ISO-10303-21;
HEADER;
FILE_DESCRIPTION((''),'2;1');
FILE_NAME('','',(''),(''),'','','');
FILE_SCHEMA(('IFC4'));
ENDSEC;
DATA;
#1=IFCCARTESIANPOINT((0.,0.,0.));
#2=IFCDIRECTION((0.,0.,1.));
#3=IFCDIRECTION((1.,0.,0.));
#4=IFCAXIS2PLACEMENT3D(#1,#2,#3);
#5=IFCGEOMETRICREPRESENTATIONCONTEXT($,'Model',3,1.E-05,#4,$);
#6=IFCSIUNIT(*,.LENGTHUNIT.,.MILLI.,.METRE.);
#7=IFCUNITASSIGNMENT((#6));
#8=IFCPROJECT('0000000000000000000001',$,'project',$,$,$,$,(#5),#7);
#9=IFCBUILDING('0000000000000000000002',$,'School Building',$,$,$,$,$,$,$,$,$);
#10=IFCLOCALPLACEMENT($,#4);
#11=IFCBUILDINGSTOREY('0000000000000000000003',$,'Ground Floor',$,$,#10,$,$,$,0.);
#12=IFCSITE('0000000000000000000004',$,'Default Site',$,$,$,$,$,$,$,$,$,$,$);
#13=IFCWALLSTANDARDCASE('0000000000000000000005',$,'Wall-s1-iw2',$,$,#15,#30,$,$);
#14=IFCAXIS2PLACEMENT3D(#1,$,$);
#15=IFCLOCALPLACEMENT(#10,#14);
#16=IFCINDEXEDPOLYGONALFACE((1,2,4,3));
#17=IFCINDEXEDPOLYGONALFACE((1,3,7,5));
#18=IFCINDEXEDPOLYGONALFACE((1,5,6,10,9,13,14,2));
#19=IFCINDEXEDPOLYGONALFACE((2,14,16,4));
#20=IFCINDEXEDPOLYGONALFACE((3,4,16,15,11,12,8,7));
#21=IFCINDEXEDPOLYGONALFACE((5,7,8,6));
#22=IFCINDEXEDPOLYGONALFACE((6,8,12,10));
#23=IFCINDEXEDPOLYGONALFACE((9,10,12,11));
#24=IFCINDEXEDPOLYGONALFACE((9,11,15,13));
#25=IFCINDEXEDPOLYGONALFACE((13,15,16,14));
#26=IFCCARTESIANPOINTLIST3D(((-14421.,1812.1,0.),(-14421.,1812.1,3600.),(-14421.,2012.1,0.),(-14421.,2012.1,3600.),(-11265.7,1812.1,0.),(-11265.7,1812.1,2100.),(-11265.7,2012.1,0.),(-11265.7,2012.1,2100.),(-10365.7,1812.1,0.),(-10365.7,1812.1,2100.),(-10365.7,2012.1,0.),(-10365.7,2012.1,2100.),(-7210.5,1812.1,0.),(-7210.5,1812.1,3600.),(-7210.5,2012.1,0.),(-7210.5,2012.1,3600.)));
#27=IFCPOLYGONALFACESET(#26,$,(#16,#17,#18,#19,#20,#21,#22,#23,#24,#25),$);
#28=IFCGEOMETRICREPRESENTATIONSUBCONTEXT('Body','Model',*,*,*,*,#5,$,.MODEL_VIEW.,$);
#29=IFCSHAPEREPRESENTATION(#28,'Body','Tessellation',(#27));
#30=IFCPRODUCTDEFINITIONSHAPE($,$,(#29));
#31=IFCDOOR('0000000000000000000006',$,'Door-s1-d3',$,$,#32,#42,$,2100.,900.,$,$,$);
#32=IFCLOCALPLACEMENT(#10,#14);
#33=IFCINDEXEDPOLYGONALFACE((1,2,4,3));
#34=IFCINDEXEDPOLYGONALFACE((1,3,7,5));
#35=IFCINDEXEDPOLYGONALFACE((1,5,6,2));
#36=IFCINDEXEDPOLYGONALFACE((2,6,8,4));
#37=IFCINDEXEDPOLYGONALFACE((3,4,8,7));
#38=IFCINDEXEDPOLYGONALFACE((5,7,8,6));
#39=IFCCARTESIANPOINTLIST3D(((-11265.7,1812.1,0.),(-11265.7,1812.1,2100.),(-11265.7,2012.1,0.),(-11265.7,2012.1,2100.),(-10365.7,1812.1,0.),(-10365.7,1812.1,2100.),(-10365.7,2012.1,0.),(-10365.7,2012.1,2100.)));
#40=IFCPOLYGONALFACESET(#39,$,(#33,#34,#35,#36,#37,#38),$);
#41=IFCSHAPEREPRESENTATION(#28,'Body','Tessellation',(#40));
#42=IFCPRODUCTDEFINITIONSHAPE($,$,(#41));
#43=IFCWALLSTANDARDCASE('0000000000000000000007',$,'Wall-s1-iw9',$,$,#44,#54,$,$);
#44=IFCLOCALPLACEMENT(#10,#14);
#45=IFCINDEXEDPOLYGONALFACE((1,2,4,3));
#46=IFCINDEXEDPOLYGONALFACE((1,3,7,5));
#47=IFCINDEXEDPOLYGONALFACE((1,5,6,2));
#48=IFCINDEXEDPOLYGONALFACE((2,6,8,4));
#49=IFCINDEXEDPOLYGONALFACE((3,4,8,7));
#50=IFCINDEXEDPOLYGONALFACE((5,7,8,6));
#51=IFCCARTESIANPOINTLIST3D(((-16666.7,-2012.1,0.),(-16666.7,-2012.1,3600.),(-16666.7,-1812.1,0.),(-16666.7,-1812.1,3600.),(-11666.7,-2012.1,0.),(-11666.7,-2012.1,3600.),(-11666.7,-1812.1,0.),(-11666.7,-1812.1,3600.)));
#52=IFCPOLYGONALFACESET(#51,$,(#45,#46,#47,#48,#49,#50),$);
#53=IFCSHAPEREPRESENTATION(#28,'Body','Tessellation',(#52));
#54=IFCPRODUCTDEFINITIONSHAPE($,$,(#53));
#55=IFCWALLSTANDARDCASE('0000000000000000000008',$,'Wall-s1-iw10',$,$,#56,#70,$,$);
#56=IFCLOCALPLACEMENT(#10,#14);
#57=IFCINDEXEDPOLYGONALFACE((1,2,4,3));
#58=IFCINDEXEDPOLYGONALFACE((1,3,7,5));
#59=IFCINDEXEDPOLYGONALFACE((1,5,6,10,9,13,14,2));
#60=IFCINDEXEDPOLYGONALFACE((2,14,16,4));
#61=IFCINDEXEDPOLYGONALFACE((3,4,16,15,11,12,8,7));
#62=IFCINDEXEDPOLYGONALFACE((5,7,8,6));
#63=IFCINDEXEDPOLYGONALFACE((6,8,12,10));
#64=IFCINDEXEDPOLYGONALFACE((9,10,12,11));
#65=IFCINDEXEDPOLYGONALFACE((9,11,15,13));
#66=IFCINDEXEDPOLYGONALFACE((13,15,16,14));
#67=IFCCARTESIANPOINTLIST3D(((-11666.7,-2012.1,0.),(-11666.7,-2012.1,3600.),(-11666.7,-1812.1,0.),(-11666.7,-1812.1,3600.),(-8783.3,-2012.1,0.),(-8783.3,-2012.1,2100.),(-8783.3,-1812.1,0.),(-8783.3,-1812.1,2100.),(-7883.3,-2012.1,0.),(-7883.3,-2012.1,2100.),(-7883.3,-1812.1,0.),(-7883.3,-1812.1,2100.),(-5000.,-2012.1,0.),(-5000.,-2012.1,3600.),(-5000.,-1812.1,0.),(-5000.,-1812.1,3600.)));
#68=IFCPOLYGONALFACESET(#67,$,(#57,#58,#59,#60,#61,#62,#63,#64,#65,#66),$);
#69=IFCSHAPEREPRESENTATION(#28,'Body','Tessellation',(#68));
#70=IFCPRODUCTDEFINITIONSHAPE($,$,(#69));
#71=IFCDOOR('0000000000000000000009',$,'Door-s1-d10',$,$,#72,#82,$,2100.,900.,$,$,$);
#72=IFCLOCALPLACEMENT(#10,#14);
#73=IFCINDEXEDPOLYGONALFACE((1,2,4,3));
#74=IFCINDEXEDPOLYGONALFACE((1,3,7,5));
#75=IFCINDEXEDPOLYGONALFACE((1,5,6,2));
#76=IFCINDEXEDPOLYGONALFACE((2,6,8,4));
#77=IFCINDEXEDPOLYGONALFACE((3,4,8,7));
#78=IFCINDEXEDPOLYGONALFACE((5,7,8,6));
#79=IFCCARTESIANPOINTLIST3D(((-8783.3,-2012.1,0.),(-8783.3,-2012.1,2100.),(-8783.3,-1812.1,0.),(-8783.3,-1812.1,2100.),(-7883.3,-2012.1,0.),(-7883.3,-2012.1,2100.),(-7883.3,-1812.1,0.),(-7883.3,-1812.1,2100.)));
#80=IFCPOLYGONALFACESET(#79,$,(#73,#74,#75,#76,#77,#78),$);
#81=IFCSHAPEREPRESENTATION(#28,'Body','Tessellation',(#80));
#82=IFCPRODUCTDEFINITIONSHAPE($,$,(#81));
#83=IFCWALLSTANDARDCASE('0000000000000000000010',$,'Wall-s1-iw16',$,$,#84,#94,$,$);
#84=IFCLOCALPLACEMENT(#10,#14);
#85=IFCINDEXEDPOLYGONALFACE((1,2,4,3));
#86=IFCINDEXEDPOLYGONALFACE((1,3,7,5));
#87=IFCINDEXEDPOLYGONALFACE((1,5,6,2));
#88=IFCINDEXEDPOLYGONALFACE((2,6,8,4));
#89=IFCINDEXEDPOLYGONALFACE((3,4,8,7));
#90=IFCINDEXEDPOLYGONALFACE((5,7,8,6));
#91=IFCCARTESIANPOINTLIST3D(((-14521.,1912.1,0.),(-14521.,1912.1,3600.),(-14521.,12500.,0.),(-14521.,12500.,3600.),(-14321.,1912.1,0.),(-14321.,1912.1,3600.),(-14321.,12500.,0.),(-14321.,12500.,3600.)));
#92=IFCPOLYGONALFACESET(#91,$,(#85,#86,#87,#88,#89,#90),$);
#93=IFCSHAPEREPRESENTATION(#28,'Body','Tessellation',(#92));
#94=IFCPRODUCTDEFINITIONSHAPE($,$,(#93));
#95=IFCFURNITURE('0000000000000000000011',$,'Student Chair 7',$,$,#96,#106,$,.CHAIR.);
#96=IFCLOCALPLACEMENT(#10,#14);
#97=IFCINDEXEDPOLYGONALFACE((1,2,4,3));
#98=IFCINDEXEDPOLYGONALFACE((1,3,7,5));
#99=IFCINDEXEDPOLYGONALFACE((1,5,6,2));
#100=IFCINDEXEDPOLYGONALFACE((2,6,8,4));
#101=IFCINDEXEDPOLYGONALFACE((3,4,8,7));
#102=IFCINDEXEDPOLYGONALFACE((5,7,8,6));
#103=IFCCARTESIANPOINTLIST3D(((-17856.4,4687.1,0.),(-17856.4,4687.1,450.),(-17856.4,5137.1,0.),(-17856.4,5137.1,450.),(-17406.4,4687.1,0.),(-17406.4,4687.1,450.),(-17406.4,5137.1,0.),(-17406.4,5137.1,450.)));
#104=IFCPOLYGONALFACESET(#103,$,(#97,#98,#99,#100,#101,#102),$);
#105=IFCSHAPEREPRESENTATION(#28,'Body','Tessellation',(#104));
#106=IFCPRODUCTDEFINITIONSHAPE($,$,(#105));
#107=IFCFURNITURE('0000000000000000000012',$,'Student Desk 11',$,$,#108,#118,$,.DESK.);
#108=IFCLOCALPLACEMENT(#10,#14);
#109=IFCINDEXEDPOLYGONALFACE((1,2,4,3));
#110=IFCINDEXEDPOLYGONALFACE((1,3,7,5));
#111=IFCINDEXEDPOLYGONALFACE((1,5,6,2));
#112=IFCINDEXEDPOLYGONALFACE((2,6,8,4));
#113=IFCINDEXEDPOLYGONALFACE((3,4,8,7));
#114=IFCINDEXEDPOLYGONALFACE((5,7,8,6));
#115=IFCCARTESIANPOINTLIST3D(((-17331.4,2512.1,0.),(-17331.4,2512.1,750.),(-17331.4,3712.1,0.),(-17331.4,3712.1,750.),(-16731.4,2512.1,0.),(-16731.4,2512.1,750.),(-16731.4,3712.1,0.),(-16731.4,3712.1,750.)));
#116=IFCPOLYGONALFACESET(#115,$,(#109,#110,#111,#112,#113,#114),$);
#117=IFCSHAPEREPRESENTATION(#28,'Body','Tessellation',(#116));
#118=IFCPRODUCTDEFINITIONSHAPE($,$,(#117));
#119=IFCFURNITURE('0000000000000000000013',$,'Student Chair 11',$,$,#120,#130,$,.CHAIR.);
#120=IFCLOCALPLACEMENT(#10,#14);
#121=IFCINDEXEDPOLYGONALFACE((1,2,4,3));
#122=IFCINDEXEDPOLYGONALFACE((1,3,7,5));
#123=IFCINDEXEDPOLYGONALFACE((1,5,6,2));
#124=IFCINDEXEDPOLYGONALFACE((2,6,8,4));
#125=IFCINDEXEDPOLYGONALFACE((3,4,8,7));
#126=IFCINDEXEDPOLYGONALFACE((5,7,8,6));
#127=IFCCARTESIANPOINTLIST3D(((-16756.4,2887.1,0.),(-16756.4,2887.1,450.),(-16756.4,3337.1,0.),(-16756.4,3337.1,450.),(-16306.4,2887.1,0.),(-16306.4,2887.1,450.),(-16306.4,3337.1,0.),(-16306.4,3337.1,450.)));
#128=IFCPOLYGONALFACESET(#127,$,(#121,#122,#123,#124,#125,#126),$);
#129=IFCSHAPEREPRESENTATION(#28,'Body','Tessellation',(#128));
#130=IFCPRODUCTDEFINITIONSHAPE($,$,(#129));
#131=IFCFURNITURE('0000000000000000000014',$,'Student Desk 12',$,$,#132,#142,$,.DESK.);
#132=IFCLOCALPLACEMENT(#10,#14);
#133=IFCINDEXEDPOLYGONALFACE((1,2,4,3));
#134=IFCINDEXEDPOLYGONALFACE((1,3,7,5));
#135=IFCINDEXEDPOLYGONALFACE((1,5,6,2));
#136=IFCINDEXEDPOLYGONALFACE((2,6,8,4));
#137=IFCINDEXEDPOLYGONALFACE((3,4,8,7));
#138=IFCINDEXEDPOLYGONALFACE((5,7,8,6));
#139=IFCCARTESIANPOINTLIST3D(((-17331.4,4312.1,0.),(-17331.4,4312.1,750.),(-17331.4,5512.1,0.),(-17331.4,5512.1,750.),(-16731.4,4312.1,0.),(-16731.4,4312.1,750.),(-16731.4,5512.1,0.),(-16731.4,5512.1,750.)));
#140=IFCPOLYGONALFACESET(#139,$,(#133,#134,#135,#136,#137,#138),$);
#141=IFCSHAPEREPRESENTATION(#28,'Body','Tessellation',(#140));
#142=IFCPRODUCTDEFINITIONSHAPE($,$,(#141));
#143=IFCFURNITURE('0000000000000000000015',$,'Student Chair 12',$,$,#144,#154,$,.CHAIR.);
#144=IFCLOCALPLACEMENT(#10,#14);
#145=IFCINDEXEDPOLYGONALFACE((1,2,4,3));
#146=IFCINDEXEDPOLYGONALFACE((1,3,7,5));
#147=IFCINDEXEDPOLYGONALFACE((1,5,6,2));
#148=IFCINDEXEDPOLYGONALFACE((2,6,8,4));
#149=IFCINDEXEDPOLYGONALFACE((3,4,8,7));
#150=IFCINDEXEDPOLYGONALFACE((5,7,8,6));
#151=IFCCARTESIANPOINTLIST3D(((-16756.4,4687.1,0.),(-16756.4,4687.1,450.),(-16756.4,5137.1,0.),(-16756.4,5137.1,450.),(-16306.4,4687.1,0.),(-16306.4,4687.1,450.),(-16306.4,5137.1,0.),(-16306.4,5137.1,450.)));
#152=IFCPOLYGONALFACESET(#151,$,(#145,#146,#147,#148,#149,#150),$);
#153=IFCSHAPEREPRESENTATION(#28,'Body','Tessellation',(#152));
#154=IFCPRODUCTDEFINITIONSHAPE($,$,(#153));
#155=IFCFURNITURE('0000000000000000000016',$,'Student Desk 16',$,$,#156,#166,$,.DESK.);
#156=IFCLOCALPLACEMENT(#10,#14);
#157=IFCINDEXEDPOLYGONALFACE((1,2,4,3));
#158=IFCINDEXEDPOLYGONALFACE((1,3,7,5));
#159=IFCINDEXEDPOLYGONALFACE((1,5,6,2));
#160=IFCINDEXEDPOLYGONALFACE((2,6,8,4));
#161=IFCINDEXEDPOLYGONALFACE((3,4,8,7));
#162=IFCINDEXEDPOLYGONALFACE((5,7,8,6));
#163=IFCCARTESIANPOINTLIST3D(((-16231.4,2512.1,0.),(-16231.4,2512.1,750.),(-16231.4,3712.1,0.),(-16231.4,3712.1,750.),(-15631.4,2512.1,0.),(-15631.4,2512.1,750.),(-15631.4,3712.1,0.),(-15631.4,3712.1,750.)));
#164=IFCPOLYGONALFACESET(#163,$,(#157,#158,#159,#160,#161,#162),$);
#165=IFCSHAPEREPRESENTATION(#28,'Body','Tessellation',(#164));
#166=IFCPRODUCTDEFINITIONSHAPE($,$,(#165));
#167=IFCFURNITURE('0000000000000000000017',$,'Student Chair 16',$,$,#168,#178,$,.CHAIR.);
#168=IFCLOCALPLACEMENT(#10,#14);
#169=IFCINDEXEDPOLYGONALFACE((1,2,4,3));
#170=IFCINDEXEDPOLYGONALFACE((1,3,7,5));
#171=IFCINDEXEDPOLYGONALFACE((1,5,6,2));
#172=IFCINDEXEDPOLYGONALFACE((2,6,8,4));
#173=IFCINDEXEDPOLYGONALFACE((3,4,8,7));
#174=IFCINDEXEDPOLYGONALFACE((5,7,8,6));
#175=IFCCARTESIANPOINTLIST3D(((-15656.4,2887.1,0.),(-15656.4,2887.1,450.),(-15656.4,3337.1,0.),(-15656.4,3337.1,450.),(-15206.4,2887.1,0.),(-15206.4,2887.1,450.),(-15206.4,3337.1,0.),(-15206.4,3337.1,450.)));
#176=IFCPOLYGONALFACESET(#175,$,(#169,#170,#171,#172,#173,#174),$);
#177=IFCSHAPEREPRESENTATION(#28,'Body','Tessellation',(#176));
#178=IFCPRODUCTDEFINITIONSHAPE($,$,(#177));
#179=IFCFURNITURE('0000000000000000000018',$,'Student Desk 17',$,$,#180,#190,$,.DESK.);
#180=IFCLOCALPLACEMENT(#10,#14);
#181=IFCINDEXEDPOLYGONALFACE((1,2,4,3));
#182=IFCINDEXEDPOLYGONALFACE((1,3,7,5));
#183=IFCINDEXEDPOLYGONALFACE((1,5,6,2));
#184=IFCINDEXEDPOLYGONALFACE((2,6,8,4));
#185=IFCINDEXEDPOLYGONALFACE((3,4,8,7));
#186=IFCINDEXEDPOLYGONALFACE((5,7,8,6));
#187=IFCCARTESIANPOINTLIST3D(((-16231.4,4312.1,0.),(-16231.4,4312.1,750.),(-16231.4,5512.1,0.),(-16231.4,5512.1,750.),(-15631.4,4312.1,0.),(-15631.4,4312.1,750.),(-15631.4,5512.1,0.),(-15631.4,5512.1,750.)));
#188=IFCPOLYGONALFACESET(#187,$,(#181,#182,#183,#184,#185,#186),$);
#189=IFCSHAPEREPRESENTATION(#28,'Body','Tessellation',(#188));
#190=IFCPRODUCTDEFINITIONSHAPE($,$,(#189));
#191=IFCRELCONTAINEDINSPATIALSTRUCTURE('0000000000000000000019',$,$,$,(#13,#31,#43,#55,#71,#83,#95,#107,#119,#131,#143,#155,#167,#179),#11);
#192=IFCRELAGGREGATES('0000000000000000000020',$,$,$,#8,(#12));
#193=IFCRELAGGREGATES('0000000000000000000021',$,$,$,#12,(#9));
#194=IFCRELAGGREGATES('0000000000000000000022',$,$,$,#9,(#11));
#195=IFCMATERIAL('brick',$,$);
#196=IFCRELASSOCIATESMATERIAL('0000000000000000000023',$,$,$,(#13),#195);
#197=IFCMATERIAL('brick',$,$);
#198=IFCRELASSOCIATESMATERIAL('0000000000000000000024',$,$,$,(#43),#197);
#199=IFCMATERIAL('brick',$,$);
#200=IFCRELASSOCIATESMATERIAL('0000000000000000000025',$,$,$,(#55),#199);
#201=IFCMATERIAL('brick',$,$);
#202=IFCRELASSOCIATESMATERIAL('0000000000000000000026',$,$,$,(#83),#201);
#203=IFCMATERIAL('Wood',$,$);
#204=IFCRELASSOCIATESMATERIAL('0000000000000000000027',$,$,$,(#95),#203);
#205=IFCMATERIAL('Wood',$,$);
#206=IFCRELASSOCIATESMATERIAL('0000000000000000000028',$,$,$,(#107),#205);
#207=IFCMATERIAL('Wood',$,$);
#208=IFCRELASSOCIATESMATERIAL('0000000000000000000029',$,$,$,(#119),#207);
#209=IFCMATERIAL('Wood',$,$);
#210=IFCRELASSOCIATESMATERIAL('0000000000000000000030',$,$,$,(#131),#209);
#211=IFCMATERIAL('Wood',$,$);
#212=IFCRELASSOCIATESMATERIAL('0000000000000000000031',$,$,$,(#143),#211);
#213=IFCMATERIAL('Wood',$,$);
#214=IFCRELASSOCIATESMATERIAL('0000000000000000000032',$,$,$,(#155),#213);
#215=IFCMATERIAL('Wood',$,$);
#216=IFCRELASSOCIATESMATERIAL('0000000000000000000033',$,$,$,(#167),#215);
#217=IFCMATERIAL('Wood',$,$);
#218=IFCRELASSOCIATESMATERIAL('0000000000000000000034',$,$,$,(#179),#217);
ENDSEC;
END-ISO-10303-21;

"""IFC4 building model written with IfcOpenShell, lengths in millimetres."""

from ifc_helpers import new_model, si_unit, frame, frame_2d, origin_with_axes, origin_2d, place, context, subcontext, project, spatial, rectangle, extrude, material, element, fill, save


model = new_model("IFC4")

# Units and contexts
model_context = context("Model", 3, precision=1e-05, world=origin_with_axes())
body_context = subcontext(model_context, "Body", "Model", "MODEL_VIEW")
ifc_project = project(units=[si_unit("LENGTHUNIT", "METRE", prefix="MILLI")], contexts=[model_context])

# Site, building, storey
site = spatial("IfcSite", under=ifc_project, Name="Default Site")
building = spatial("IfcBuilding", under=site, Name="School Building")
storey_placement = place(None, origin_with_axes())
storey = spatial("IfcBuildingStorey", under=building, at=storey_placement, Name="Ground Floor", Elevation=0.0)

# Wall, opening, door
ifc_material_1 = material(Name="brick")
wall_1_placement = place(storey_placement, frame((-14421.0, 1912.1, 0.0), z_axis=(0.0, 0.0, 1.0), x_axis=(1.0, 0.0, 0.0)))
wall_1 = element("IfcWallStandardCase", 1, at=wall_1_placement, inside=storey, material=ifc_material_1, Name="Wall-s1-iw2", context=body_context, shape_type="SweptSolid", body=[
    extrude(rectangle(XDim=7210.5, YDim=200.0, at=frame_2d((3605.2, 0.0))), origin_with_axes(), (0.0, 0.0, 1.0), 3600.0),
])
opening_1_placement = place(wall_1_placement, frame((3155.2, 0.0, 0.0), z_axis=(0.0, 0.0, 1.0), x_axis=(1.0, 0.0, 0.0)))
opening_1 = element("IfcOpeningElement", 2, at=opening_1_placement, cuts=wall_1, context=body_context, shape_type="SweptSolid", body=[
    extrude(rectangle(XDim=900.0, YDim=400.0, at=frame_2d((450.0, 0.0))), origin_with_axes(), (0.0, 0.0, 1.0), 2100.0),
])
door_1_placement = place(storey_placement, frame((-11265.7, 1912.1, 0.0), z_axis=(0.0, 0.0, 1.0), x_axis=(1.0, 0.0, 0.0)))
door_1 = element("IfcDoor", 3, at=door_1_placement, inside=storey, Name="Door-s1-d3", OverallHeight=2100.0, OverallWidth=900.0, context=body_context, shape_type="SweptSolid", body=[
    extrude(rectangle(XDim=900.0, YDim=200.0, at=frame_2d((450.0, 0.0))), origin_with_axes(), (0.0, 0.0, 1.0), 2100.0),
])
fill(opening_1, door_1)

# Wall
ifc_material_2 = material(Name="brick")
wall_2_placement = place(storey_placement, frame((-16666.7, -1912.1, 0.0), z_axis=(0.0, 0.0, 1.0), x_axis=(1.0, 0.0, 0.0)))
element("IfcWallStandardCase", 4, at=wall_2_placement, inside=storey, material=ifc_material_2, Name="Wall-s1-iw9", context=body_context, shape_type="SweptSolid", body=[
    extrude(rectangle(XDim=5000.0, YDim=200.0, at=frame_2d((2500.0, 0.0))), origin_with_axes(), (0.0, 0.0, 1.0), 3600.0),
])

# Wall, opening, door
ifc_material_3 = material(Name="brick")
wall_3_placement = place(storey_placement, frame((-11666.7, -1912.1, 0.0), z_axis=(0.0, 0.0, 1.0), x_axis=(1.0, 0.0, 0.0)))
wall_3 = element("IfcWallStandardCase", 5, at=wall_3_placement, inside=storey, material=ifc_material_3, Name="Wall-s1-iw10", context=body_context, shape_type="SweptSolid", body=[
    extrude(rectangle(XDim=6666.7, YDim=200.0, at=frame_2d((3333.3, 0.0))), origin_with_axes(), (0.0, 0.0, 1.0), 3600.0),
])
opening_2_placement = place(wall_3_placement, frame((2883.3, 0.0, 0.0), z_axis=(0.0, 0.0, 1.0), x_axis=(1.0, 0.0, 0.0)))
opening_2 = element("IfcOpeningElement", 6, at=opening_2_placement, cuts=wall_3, context=body_context, shape_type="SweptSolid", body=[
    extrude(rectangle(XDim=900.0, YDim=400.0, at=frame_2d((450.0, 0.0))), origin_with_axes(), (0.0, 0.0, 1.0), 2100.0),
])
door_2_placement = place(storey_placement, frame((-8783.3, -1912.1, 0.0), z_axis=(0.0, 0.0, 1.0), x_axis=(1.0, 0.0, 0.0)))
door_2 = element("IfcDoor", 7, at=door_2_placement, inside=storey, Name="Door-s1-d10", OverallHeight=2100.0, OverallWidth=900.0, context=body_context, shape_type="SweptSolid", body=[
    extrude(rectangle(XDim=900.0, YDim=200.0, at=frame_2d((450.0, 0.0))), origin_with_axes(), (0.0, 0.0, 1.0), 2100.0),
])
fill(opening_2, door_2)

# Wall
ifc_material_4 = material(Name="brick")
wall_4_placement = place(storey_placement, frame((-14421.0, 1912.1, 0.0), z_axis=(0.0, 0.0, 1.0), x_axis=(0.0, 1.0, 0.0)))
element("IfcWallStandardCase", 8, at=wall_4_placement, inside=storey, material=ifc_material_4, Name="Wall-s1-iw16", context=body_context, shape_type="SweptSolid", body=[
    extrude(rectangle(XDim=10587.9, YDim=200.0, at=frame_2d((5293.9, 0.0))), origin_with_axes(), (0.0, 0.0, 1.0), 3600.0),
])

# Furniture
ifc_material_5 = material(Name="Wood")
furniture_1_placement = place(storey_placement, frame((-17631.4, 4912.1, 0.0), z_axis=(0.0, 0.0, 1.0), x_axis=(1.0, 0.0, 0.0)))
element("IfcFurniture", 9, at=furniture_1_placement, inside=storey, material=ifc_material_5, Name="Student Chair 7", PredefinedType="CHAIR", context=body_context, shape_type="SweptSolid", body=[
    extrude(rectangle(XDim=450.0, YDim=450.0, at=origin_2d()), origin_with_axes(), (0.0, 0.0, 1.0), 450.0),
])
ifc_material_6 = material(Name="Wood")
furniture_2_placement = place(storey_placement, frame((-17031.4, 3112.1, 0.0), z_axis=(0.0, 0.0, 1.0), x_axis=(0.0, 1.0, 0.0)))
element("IfcFurniture", 10, at=furniture_2_placement, inside=storey, material=ifc_material_6, Name="Student Desk 11", PredefinedType="DESK", context=body_context, shape_type="SweptSolid", body=[
    extrude(rectangle(XDim=1200.0, YDim=600.0, at=origin_2d()), origin_with_axes(), (0.0, 0.0, 1.0), 750.0),
])
ifc_material_7 = material(Name="Wood")
furniture_3_placement = place(storey_placement, frame((-16531.4, 3112.1, 0.0), z_axis=(0.0, 0.0, 1.0), x_axis=(1.0, 0.0, 0.0)))
element("IfcFurniture", 11, at=furniture_3_placement, inside=storey, material=ifc_material_7, Name="Student Chair 11", PredefinedType="CHAIR", context=body_context, shape_type="SweptSolid", body=[
    extrude(rectangle(XDim=450.0, YDim=450.0, at=origin_2d()), origin_with_axes(), (0.0, 0.0, 1.0), 450.0),
])
ifc_material_8 = material(Name="Wood")
furniture_4_placement = place(storey_placement, frame((-17031.4, 4912.1, 0.0), z_axis=(0.0, 0.0, 1.0), x_axis=(0.0, 1.0, 0.0)))
element("IfcFurniture", 12, at=furniture_4_placement, inside=storey, material=ifc_material_8, Name="Student Desk 12", PredefinedType="DESK", context=body_context, shape_type="SweptSolid", body=[
    extrude(rectangle(XDim=1200.0, YDim=600.0, at=origin_2d()), origin_with_axes(), (0.0, 0.0, 1.0), 750.0),
])
ifc_material_9 = material(Name="Wood")
furniture_5_placement = place(storey_placement, frame((-16531.4, 4912.1, 0.0), z_axis=(0.0, 0.0, 1.0), x_axis=(1.0, 0.0, 0.0)))
element("IfcFurniture", 13, at=furniture_5_placement, inside=storey, material=ifc_material_9, Name="Student Chair 12", PredefinedType="CHAIR", context=body_context, shape_type="SweptSolid", body=[
    extrude(rectangle(XDim=450.0, YDim=450.0, at=origin_2d()), origin_with_axes(), (0.0, 0.0, 1.0), 450.0),
])
ifc_material_10 = material(Name="Wood")
furniture_6_placement = place(storey_placement, frame((-15931.4, 3112.1, 0.0), z_axis=(0.0, 0.0, 1.0), x_axis=(0.0, 1.0, 0.0)))
element("IfcFurniture", 14, at=furniture_6_placement, inside=storey, material=ifc_material_10, Name="Student Desk 16", PredefinedType="DESK", context=body_context, shape_type="SweptSolid", body=[
    extrude(rectangle(XDim=1200.0, YDim=600.0, at=origin_2d()), origin_with_axes(), (0.0, 0.0, 1.0), 750.0),
])
ifc_material_11 = material(Name="Wood")
furniture_7_placement = place(storey_placement, frame((-15431.4, 3112.1, 0.0), z_axis=(0.0, 0.0, 1.0), x_axis=(1.0, 0.0, 0.0)))
element("IfcFurniture", 15, at=furniture_7_placement, inside=storey, material=ifc_material_11, Name="Student Chair 16", PredefinedType="CHAIR", context=body_context, shape_type="SweptSolid", body=[
    extrude(rectangle(XDim=450.0, YDim=450.0, at=origin_2d()), origin_with_axes(), (0.0, 0.0, 1.0), 450.0),
])
ifc_material_12 = material(Name="Wood")
furniture_8_placement = place(storey_placement, frame((-15931.4, 4912.1, 0.0), z_axis=(0.0, 0.0, 1.0), x_axis=(0.0, 1.0, 0.0)))
element("IfcFurniture", 16, at=furniture_8_placement, inside=storey, material=ifc_material_12, Name="Student Desk 17", PredefinedType="DESK", context=body_context, shape_type="SweptSolid", body=[
    extrude(rectangle(XDim=1200.0, YDim=600.0, at=origin_2d()), origin_with_axes(), (0.0, 0.0, 1.0), 750.0),
])

save(model, "model.ifc")
